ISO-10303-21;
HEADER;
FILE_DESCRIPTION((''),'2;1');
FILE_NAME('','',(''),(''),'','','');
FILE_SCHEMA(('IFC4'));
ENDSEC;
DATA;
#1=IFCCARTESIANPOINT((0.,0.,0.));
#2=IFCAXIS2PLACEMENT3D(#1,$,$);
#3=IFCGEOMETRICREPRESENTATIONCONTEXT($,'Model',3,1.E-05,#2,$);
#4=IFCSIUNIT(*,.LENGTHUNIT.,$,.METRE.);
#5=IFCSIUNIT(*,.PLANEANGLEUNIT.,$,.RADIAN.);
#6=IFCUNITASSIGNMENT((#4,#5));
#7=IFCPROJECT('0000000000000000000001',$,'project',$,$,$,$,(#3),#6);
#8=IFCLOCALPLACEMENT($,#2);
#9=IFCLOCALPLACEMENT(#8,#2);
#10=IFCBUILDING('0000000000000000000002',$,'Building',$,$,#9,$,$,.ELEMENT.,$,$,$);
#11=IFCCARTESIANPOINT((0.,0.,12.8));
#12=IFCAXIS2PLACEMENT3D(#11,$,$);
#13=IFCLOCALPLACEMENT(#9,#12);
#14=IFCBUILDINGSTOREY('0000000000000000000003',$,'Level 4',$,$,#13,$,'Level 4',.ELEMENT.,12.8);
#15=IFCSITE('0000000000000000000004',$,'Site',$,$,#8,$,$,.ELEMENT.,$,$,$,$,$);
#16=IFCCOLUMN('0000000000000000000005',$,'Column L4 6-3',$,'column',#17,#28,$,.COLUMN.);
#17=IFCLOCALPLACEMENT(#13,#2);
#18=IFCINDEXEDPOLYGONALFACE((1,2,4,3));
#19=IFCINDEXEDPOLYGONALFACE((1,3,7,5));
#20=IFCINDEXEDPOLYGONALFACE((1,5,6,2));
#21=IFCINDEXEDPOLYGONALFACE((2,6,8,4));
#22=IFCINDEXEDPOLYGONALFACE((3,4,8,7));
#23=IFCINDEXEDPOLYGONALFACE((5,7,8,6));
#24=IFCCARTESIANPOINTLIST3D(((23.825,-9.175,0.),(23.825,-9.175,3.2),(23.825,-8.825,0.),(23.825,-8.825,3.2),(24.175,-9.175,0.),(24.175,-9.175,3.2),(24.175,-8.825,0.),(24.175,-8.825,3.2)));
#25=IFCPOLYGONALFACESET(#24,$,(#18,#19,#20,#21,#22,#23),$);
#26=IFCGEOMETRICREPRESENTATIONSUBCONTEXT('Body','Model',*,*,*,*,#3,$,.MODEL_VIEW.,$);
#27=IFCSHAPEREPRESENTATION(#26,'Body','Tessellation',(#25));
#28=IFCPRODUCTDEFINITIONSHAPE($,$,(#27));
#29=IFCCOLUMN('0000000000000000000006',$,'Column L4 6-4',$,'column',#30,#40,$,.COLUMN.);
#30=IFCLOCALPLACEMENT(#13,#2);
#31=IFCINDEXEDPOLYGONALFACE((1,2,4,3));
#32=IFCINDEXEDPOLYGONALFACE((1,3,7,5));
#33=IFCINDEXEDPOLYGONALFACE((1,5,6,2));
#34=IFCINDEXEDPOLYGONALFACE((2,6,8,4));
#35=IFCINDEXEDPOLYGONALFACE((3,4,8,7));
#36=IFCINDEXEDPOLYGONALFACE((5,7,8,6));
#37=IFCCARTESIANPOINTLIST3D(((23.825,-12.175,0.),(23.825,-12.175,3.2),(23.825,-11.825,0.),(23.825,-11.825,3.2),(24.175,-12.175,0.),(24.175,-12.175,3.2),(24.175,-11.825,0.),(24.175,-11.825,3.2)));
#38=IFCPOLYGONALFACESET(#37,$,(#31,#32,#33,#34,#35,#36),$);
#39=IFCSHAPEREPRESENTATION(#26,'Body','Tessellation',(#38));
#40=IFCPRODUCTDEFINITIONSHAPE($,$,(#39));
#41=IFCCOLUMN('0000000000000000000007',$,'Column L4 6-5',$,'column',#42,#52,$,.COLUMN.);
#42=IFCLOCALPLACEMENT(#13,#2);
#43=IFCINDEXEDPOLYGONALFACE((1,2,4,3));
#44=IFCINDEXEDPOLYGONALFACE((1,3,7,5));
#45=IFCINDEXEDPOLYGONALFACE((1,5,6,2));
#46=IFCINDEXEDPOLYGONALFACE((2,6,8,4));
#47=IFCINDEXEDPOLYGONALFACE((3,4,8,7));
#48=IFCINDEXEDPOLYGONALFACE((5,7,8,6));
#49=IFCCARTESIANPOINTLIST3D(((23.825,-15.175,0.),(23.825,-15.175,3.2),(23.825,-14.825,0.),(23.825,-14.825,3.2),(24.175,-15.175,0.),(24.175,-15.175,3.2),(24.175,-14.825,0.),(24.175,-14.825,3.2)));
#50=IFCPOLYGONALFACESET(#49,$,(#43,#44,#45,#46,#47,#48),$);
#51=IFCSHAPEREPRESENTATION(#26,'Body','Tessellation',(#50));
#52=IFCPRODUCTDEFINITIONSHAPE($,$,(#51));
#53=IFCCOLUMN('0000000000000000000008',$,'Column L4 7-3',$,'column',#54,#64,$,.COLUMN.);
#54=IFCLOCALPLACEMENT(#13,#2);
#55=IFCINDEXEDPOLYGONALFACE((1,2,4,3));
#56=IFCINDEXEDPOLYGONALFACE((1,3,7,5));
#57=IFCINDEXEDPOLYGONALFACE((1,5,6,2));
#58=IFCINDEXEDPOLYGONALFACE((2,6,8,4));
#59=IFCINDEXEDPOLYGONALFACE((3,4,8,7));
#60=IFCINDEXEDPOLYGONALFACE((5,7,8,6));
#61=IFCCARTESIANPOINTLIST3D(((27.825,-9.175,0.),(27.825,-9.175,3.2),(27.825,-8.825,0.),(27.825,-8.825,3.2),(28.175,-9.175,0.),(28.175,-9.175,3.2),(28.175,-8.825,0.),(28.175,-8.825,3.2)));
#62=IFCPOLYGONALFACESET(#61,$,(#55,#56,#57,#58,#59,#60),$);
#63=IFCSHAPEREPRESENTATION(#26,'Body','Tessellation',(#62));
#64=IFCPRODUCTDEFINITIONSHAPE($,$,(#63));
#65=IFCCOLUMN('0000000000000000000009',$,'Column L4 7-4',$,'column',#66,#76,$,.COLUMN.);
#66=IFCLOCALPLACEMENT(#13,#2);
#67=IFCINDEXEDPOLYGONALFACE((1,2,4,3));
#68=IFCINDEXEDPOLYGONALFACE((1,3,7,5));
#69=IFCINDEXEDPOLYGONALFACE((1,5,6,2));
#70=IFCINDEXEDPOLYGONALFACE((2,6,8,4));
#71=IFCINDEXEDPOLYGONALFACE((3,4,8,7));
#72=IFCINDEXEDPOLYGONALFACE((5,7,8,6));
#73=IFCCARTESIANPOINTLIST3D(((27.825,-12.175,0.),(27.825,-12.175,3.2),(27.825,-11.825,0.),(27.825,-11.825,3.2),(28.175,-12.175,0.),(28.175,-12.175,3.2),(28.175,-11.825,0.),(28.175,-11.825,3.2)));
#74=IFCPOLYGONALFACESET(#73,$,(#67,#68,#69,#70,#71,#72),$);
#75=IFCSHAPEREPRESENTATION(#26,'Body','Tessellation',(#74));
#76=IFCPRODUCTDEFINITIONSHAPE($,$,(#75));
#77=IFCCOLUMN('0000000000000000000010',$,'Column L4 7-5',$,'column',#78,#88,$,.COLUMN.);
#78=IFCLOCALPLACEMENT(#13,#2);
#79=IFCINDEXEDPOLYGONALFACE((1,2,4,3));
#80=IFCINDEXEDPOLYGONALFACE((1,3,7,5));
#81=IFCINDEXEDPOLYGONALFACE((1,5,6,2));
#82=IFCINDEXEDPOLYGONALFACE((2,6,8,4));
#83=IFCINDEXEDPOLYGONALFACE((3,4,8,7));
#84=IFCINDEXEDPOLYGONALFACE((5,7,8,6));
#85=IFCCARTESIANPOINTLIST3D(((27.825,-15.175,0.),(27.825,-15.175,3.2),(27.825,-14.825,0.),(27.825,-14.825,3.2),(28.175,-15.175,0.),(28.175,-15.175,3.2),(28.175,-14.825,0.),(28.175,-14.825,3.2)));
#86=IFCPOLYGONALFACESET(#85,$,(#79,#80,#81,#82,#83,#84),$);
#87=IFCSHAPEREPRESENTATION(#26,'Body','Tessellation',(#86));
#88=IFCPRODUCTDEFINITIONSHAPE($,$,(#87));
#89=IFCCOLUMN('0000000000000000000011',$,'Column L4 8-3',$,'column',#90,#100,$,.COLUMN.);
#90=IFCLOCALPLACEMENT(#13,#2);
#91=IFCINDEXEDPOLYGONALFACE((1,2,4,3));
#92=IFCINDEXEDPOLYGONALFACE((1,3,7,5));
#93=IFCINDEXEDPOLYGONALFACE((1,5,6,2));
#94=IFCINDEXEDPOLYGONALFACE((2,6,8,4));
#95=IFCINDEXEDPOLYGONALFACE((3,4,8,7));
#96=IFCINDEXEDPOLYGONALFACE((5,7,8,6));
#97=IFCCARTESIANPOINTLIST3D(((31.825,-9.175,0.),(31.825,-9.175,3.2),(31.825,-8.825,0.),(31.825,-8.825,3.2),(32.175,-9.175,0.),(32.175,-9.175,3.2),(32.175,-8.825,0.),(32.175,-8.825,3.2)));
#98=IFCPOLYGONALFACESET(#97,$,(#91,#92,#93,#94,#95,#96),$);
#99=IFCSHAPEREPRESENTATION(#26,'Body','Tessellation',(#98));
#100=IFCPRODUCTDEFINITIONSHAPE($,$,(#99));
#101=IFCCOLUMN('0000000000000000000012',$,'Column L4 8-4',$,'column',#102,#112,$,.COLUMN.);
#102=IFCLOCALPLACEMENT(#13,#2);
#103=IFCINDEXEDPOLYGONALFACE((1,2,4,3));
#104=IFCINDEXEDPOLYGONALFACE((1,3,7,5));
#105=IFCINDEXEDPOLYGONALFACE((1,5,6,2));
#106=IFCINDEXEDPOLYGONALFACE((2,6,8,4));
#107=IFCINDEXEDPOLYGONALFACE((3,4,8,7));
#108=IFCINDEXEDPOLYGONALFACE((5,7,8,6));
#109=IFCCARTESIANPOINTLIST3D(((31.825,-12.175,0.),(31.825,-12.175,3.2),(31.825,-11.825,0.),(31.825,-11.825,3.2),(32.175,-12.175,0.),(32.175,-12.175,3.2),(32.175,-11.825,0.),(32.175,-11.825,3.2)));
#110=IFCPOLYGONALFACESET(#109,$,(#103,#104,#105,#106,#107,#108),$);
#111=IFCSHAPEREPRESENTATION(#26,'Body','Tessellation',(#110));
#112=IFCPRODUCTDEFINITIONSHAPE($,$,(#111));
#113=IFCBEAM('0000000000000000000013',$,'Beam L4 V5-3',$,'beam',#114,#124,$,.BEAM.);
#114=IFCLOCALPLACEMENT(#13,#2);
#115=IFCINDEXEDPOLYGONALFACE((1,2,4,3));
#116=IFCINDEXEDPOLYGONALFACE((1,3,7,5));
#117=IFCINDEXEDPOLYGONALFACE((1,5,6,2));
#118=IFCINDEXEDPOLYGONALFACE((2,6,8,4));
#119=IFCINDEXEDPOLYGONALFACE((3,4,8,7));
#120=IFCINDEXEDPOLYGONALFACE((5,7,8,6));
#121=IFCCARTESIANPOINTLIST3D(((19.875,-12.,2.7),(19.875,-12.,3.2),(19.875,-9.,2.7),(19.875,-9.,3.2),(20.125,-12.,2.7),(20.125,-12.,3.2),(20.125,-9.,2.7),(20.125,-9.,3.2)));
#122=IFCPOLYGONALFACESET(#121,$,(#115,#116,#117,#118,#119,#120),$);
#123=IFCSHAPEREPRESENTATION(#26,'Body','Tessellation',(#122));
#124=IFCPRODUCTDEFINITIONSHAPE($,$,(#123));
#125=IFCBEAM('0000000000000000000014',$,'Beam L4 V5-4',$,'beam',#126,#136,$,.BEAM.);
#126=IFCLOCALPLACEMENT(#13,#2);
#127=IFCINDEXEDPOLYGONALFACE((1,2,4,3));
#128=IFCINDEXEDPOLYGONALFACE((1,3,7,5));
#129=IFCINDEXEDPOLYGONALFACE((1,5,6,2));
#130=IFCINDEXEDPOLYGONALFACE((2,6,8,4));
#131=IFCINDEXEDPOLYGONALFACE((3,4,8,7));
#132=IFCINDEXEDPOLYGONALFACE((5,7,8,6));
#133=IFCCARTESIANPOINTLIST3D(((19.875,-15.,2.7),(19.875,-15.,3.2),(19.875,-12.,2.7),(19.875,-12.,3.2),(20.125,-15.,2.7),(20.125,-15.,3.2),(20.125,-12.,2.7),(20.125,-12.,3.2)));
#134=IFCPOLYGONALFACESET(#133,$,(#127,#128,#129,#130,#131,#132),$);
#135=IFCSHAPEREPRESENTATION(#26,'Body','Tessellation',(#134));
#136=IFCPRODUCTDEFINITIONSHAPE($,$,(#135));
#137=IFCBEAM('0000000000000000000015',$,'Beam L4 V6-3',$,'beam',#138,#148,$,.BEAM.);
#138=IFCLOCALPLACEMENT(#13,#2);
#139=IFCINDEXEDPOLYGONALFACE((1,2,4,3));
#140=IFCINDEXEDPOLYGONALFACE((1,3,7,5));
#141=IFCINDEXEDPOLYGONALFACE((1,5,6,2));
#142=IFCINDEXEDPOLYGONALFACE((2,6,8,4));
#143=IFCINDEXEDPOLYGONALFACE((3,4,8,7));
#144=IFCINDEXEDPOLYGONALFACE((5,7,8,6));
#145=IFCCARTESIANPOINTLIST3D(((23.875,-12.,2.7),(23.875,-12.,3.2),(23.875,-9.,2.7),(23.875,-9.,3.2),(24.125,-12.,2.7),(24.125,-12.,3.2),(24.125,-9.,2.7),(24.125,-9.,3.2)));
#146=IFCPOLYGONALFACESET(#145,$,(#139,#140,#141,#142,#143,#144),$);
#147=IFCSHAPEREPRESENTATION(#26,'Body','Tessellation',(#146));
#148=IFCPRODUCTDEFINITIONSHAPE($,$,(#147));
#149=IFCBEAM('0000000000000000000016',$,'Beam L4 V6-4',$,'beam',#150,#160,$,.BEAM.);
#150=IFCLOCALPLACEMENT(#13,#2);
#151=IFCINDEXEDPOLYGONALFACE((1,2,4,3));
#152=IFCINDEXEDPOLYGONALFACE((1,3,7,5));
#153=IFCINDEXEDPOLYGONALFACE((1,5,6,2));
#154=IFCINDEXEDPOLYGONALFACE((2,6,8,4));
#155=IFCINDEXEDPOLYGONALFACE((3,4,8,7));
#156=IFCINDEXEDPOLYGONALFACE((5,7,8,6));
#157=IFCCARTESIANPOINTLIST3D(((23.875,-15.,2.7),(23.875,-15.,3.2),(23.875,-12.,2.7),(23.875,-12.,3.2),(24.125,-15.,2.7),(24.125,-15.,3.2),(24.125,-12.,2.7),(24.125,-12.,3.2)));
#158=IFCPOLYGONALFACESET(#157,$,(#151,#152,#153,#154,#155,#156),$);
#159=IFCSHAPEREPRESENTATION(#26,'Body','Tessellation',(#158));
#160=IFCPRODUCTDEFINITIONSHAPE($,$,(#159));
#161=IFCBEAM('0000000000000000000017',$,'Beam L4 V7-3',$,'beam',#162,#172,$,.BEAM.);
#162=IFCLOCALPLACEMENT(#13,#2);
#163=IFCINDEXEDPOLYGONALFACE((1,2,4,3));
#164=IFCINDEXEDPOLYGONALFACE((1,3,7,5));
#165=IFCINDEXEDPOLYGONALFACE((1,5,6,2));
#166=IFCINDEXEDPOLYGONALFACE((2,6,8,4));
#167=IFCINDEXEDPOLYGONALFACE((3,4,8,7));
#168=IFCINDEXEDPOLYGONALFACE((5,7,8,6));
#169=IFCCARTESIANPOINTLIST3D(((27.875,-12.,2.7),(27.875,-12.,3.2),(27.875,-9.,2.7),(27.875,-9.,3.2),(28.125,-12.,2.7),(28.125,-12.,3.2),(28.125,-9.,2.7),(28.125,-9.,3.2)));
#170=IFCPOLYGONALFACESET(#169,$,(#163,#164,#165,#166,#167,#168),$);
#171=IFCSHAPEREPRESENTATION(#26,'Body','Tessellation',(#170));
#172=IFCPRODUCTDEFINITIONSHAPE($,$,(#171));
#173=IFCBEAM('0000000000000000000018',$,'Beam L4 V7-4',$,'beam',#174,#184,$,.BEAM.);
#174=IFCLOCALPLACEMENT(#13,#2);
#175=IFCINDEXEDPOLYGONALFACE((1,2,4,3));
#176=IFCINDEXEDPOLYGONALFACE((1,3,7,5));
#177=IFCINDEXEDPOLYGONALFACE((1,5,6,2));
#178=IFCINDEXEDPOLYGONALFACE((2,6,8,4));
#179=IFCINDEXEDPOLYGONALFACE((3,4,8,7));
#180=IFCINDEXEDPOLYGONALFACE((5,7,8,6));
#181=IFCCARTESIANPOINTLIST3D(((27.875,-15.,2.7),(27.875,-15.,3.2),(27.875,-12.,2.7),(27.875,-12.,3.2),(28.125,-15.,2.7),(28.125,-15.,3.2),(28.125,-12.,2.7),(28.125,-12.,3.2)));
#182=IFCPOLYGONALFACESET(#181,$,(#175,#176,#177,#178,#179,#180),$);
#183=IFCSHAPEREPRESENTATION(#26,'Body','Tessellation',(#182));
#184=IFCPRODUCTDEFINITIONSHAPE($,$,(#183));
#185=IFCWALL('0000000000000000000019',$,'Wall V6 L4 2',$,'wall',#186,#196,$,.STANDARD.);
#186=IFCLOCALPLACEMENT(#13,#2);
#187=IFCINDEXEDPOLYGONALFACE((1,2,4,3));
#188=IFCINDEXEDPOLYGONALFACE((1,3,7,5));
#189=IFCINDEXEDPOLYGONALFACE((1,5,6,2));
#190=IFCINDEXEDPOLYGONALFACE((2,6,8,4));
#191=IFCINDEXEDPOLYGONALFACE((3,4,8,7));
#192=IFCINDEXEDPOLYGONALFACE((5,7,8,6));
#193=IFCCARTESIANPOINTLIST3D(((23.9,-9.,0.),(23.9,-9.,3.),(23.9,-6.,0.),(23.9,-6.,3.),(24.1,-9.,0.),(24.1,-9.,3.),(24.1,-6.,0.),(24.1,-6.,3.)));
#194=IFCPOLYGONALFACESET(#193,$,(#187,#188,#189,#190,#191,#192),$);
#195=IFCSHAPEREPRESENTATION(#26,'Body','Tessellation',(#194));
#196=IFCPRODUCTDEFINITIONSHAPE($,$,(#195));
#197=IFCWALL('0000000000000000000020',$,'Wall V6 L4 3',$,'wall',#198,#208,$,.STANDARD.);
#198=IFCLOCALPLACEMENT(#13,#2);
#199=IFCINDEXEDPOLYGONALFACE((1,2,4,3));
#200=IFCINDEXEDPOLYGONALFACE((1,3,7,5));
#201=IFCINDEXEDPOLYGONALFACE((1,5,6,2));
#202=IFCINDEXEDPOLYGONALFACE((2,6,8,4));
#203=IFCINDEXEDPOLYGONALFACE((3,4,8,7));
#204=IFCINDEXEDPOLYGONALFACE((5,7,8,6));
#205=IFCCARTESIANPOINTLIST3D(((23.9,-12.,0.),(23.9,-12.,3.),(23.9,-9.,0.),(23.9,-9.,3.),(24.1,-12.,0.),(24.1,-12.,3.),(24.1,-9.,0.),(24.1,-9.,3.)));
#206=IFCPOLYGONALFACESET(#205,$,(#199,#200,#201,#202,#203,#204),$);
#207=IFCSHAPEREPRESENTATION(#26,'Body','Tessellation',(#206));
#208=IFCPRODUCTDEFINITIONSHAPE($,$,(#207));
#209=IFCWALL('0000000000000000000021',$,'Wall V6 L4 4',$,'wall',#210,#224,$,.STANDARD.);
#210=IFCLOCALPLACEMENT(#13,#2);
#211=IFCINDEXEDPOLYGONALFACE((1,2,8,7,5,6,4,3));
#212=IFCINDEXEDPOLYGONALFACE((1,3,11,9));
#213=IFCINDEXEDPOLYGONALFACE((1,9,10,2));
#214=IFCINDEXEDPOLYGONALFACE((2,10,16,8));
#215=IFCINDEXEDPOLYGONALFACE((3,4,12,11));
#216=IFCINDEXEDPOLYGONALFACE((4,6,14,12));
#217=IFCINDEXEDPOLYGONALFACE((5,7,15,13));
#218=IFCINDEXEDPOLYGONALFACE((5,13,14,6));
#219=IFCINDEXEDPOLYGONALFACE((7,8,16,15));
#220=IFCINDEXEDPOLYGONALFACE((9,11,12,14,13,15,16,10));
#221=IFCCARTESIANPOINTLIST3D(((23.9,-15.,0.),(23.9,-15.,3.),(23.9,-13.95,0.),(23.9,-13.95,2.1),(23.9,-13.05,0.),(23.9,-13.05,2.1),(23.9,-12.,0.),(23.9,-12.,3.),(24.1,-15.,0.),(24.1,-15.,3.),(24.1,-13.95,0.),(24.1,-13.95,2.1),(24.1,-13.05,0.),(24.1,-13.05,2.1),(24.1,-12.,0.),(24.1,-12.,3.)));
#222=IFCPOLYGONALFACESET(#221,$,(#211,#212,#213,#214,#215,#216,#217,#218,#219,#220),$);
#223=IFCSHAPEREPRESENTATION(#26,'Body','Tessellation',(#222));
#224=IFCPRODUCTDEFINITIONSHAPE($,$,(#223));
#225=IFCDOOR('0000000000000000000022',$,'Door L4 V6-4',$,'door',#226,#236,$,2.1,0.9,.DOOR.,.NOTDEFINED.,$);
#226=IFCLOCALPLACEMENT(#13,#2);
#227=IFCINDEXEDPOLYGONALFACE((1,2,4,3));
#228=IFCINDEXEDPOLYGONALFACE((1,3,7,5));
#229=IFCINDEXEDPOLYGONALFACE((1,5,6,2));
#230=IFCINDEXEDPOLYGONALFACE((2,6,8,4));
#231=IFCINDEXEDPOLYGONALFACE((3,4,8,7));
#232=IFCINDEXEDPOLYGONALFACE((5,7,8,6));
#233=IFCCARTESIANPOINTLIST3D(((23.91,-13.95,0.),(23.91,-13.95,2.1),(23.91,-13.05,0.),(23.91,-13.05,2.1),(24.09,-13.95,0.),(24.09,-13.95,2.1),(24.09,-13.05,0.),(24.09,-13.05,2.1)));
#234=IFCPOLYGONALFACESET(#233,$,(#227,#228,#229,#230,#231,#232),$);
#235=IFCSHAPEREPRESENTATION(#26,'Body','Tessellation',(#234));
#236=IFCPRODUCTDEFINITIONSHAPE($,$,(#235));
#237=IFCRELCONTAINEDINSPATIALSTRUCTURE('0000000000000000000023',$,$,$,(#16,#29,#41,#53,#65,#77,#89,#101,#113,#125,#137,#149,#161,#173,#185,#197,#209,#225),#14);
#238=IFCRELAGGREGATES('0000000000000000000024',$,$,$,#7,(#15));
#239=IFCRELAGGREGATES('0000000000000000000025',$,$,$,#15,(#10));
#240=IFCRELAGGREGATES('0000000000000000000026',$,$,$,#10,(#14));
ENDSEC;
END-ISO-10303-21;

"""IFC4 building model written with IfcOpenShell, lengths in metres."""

from ifc_helpers import new_model, si_unit, frame, frame_2d, origin, origin_2d, place, context, subcontext, project, spatial, rectangle, extrude, element, fill, save


model = new_model("IFC4")

# Units and contexts
model_context = context("Model", 3, precision=1e-05, world=origin())
body_context = subcontext(model_context, "Body", "Model", "MODEL_VIEW")
ifc_project = project(units=[si_unit("LENGTHUNIT", "METRE"), si_unit("PLANEANGLEUNIT", "RADIAN")], contexts=[model_context])

# Site, building, storey
site_placement = place(None, origin())
site = spatial("IfcSite", under=ifc_project, at=site_placement, Name="Site", CompositionType="ELEMENT")
building_placement = place(site_placement, origin())
building = spatial("IfcBuilding", under=site, at=building_placement, Name="Building", CompositionType="ELEMENT")
storey_placement = place(building_placement, frame((0.0, 0.0, 12.8)))
storey = spatial("IfcBuildingStorey", under=building, at=storey_placement, Name="Level 4", LongName="Level 4", CompositionType="ELEMENT", Elevation=12.8)

# Columns
for number, where, name in (
    (1, (24.0, -9.0, 0.0), "Column L4 6-3"),
    (2, (24.0, -12.0, 0.0), "Column L4 6-4"),
    (3, (24.0, -15.0, 0.0), "Column L4 6-5"),
    (4, (28.0, -9.0, 0.0), "Column L4 7-3"),
    (5, (28.0, -12.0, 0.0), "Column L4 7-4"),
    (6, (28.0, -15.0, 0.0), "Column L4 7-5"),
    (7, (32.0, -9.0, 0.0), "Column L4 8-3"),
    (8, (32.0, -12.0, 0.0), "Column L4 8-4"),
):
    element("IfcColumn", number, at=place(storey_placement, frame(where)), inside=storey, Name=name, ObjectType="column", PredefinedType="COLUMN", context=body_context, shape_type="SweptSolid", body=[
        extrude(rectangle(XDim=0.35, YDim=0.35, at=origin_2d()), origin(), (0.0, 0.0, 1.0), 3.2),
    ])

# Beams
for number, where, z_axis, x_axis, name in (
    (9, (20.0, -9.0, 2.95), (0.0, -1.0, 0.0), (0.0, 0.0, 1.0), "Beam L4 V5-3"),
    (10, (20.0, -12.0, 2.95), (0.0, -1.0, 0.0), (0.0, 0.0, 1.0), "Beam L4 V5-4"),
    (11, (24.0, -9.0, 2.95), (0.0, -1.0, 0.0), (0.0, 0.0, 1.0), "Beam L4 V6-3"),
    (12, (24.0, -12.0, 2.95), (0.0, -1.0, 0.0), (0.0, 0.0, 1.0), "Beam L4 V6-4"),
    (13, (28.0, -9.0, 2.95), (0.0, -1.0, 0.0), (0.0, 0.0, 1.0), "Beam L4 V7-3"),
    (14, (28.0, -12.0, 2.95), (0.0, -1.0, 0.0), (0.0, 0.0, 1.0), "Beam L4 V7-4"),
):
    element("IfcBeam", number, at=place(storey_placement, frame(where, z_axis=z_axis, x_axis=x_axis)), inside=storey, Name=name, ObjectType="beam", PredefinedType="BEAM", context=body_context, shape_type="SweptSolid", body=[
        extrude(rectangle(XDim=0.5, YDim=0.25, at=origin_2d()), origin(), (0.0, 0.0, 1.0), 3.0),
    ])

# Walls
for number, where, z_axis, x_axis, name in (
    (15, (24.0, -6.0, 0.0), (0.0, 0.0, 1.0), (0.0, -1.0, 0.0), "Wall V6 L4 2"),
    (16, (24.0, -9.0, 0.0), (0.0, 0.0, 1.0), (0.0, -1.0, 0.0), "Wall V6 L4 3"),
):
    element("IfcWall", number, at=place(storey_placement, frame(where, z_axis=z_axis, x_axis=x_axis)), inside=storey, Name=name, ObjectType="wall", PredefinedType="STANDARD", context=body_context, shape_type="SweptSolid", body=[
        extrude(rectangle(XDim=3.0, YDim=0.2, at=frame_2d((1.5, 0.0))), origin(), (0.0, 0.0, 1.0), 3.0),
    ])

# Wall, opening, door
wall_1_placement = place(storey_placement, frame((24.0, -12.0, 0.0), z_axis=(0.0, 0.0, 1.0), x_axis=(0.0, -1.0, 0.0)))
wall_1 = element("IfcWall", 17, at=wall_1_placement, inside=storey, Name="Wall V6 L4 4", ObjectType="wall", PredefinedType="STANDARD", context=body_context, shape_type="SweptSolid", body=[
    extrude(rectangle(XDim=3.0, YDim=0.2, at=frame_2d((1.5, 0.0))), origin(), (0.0, 0.0, 1.0), 3.0),
])
opening_1_placement = place(storey_placement, frame((24.0, -13.5, 0.0), z_axis=(0.0, 0.0, 1.0), x_axis=(0.0, -1.0, 0.0)))
opening_1 = element("IfcOpeningElement", 18, at=opening_1_placement, cuts=wall_1, ObjectType="Opening", PredefinedType="OPENING", context=body_context, shape_type="SweptSolid", body=[
    extrude(rectangle(XDim=0.9, YDim=0.22, at=origin_2d()), origin(), (0.0, 0.0, 1.0), 2.1),
])
door_1_placement = place(storey_placement, frame((24.0, -13.5, 0.0), z_axis=(0.0, 0.0, 1.0), x_axis=(0.0, -1.0, 0.0)))
door_1 = element("IfcDoor", 19, at=door_1_placement, inside=storey, Name="Door L4 V6-4", ObjectType="door", OperationType="NOTDEFINED", OverallHeight=2.1, OverallWidth=0.9, PredefinedType="DOOR", context=body_context, shape_type="SweptSolid", body=[
    extrude(rectangle(XDim=0.9, YDim=0.18, at=origin_2d()), origin(), (0.0, 0.0, 1.0), 2.1),
])
fill(opening_1, door_1)

save(model, "model.ifc")
